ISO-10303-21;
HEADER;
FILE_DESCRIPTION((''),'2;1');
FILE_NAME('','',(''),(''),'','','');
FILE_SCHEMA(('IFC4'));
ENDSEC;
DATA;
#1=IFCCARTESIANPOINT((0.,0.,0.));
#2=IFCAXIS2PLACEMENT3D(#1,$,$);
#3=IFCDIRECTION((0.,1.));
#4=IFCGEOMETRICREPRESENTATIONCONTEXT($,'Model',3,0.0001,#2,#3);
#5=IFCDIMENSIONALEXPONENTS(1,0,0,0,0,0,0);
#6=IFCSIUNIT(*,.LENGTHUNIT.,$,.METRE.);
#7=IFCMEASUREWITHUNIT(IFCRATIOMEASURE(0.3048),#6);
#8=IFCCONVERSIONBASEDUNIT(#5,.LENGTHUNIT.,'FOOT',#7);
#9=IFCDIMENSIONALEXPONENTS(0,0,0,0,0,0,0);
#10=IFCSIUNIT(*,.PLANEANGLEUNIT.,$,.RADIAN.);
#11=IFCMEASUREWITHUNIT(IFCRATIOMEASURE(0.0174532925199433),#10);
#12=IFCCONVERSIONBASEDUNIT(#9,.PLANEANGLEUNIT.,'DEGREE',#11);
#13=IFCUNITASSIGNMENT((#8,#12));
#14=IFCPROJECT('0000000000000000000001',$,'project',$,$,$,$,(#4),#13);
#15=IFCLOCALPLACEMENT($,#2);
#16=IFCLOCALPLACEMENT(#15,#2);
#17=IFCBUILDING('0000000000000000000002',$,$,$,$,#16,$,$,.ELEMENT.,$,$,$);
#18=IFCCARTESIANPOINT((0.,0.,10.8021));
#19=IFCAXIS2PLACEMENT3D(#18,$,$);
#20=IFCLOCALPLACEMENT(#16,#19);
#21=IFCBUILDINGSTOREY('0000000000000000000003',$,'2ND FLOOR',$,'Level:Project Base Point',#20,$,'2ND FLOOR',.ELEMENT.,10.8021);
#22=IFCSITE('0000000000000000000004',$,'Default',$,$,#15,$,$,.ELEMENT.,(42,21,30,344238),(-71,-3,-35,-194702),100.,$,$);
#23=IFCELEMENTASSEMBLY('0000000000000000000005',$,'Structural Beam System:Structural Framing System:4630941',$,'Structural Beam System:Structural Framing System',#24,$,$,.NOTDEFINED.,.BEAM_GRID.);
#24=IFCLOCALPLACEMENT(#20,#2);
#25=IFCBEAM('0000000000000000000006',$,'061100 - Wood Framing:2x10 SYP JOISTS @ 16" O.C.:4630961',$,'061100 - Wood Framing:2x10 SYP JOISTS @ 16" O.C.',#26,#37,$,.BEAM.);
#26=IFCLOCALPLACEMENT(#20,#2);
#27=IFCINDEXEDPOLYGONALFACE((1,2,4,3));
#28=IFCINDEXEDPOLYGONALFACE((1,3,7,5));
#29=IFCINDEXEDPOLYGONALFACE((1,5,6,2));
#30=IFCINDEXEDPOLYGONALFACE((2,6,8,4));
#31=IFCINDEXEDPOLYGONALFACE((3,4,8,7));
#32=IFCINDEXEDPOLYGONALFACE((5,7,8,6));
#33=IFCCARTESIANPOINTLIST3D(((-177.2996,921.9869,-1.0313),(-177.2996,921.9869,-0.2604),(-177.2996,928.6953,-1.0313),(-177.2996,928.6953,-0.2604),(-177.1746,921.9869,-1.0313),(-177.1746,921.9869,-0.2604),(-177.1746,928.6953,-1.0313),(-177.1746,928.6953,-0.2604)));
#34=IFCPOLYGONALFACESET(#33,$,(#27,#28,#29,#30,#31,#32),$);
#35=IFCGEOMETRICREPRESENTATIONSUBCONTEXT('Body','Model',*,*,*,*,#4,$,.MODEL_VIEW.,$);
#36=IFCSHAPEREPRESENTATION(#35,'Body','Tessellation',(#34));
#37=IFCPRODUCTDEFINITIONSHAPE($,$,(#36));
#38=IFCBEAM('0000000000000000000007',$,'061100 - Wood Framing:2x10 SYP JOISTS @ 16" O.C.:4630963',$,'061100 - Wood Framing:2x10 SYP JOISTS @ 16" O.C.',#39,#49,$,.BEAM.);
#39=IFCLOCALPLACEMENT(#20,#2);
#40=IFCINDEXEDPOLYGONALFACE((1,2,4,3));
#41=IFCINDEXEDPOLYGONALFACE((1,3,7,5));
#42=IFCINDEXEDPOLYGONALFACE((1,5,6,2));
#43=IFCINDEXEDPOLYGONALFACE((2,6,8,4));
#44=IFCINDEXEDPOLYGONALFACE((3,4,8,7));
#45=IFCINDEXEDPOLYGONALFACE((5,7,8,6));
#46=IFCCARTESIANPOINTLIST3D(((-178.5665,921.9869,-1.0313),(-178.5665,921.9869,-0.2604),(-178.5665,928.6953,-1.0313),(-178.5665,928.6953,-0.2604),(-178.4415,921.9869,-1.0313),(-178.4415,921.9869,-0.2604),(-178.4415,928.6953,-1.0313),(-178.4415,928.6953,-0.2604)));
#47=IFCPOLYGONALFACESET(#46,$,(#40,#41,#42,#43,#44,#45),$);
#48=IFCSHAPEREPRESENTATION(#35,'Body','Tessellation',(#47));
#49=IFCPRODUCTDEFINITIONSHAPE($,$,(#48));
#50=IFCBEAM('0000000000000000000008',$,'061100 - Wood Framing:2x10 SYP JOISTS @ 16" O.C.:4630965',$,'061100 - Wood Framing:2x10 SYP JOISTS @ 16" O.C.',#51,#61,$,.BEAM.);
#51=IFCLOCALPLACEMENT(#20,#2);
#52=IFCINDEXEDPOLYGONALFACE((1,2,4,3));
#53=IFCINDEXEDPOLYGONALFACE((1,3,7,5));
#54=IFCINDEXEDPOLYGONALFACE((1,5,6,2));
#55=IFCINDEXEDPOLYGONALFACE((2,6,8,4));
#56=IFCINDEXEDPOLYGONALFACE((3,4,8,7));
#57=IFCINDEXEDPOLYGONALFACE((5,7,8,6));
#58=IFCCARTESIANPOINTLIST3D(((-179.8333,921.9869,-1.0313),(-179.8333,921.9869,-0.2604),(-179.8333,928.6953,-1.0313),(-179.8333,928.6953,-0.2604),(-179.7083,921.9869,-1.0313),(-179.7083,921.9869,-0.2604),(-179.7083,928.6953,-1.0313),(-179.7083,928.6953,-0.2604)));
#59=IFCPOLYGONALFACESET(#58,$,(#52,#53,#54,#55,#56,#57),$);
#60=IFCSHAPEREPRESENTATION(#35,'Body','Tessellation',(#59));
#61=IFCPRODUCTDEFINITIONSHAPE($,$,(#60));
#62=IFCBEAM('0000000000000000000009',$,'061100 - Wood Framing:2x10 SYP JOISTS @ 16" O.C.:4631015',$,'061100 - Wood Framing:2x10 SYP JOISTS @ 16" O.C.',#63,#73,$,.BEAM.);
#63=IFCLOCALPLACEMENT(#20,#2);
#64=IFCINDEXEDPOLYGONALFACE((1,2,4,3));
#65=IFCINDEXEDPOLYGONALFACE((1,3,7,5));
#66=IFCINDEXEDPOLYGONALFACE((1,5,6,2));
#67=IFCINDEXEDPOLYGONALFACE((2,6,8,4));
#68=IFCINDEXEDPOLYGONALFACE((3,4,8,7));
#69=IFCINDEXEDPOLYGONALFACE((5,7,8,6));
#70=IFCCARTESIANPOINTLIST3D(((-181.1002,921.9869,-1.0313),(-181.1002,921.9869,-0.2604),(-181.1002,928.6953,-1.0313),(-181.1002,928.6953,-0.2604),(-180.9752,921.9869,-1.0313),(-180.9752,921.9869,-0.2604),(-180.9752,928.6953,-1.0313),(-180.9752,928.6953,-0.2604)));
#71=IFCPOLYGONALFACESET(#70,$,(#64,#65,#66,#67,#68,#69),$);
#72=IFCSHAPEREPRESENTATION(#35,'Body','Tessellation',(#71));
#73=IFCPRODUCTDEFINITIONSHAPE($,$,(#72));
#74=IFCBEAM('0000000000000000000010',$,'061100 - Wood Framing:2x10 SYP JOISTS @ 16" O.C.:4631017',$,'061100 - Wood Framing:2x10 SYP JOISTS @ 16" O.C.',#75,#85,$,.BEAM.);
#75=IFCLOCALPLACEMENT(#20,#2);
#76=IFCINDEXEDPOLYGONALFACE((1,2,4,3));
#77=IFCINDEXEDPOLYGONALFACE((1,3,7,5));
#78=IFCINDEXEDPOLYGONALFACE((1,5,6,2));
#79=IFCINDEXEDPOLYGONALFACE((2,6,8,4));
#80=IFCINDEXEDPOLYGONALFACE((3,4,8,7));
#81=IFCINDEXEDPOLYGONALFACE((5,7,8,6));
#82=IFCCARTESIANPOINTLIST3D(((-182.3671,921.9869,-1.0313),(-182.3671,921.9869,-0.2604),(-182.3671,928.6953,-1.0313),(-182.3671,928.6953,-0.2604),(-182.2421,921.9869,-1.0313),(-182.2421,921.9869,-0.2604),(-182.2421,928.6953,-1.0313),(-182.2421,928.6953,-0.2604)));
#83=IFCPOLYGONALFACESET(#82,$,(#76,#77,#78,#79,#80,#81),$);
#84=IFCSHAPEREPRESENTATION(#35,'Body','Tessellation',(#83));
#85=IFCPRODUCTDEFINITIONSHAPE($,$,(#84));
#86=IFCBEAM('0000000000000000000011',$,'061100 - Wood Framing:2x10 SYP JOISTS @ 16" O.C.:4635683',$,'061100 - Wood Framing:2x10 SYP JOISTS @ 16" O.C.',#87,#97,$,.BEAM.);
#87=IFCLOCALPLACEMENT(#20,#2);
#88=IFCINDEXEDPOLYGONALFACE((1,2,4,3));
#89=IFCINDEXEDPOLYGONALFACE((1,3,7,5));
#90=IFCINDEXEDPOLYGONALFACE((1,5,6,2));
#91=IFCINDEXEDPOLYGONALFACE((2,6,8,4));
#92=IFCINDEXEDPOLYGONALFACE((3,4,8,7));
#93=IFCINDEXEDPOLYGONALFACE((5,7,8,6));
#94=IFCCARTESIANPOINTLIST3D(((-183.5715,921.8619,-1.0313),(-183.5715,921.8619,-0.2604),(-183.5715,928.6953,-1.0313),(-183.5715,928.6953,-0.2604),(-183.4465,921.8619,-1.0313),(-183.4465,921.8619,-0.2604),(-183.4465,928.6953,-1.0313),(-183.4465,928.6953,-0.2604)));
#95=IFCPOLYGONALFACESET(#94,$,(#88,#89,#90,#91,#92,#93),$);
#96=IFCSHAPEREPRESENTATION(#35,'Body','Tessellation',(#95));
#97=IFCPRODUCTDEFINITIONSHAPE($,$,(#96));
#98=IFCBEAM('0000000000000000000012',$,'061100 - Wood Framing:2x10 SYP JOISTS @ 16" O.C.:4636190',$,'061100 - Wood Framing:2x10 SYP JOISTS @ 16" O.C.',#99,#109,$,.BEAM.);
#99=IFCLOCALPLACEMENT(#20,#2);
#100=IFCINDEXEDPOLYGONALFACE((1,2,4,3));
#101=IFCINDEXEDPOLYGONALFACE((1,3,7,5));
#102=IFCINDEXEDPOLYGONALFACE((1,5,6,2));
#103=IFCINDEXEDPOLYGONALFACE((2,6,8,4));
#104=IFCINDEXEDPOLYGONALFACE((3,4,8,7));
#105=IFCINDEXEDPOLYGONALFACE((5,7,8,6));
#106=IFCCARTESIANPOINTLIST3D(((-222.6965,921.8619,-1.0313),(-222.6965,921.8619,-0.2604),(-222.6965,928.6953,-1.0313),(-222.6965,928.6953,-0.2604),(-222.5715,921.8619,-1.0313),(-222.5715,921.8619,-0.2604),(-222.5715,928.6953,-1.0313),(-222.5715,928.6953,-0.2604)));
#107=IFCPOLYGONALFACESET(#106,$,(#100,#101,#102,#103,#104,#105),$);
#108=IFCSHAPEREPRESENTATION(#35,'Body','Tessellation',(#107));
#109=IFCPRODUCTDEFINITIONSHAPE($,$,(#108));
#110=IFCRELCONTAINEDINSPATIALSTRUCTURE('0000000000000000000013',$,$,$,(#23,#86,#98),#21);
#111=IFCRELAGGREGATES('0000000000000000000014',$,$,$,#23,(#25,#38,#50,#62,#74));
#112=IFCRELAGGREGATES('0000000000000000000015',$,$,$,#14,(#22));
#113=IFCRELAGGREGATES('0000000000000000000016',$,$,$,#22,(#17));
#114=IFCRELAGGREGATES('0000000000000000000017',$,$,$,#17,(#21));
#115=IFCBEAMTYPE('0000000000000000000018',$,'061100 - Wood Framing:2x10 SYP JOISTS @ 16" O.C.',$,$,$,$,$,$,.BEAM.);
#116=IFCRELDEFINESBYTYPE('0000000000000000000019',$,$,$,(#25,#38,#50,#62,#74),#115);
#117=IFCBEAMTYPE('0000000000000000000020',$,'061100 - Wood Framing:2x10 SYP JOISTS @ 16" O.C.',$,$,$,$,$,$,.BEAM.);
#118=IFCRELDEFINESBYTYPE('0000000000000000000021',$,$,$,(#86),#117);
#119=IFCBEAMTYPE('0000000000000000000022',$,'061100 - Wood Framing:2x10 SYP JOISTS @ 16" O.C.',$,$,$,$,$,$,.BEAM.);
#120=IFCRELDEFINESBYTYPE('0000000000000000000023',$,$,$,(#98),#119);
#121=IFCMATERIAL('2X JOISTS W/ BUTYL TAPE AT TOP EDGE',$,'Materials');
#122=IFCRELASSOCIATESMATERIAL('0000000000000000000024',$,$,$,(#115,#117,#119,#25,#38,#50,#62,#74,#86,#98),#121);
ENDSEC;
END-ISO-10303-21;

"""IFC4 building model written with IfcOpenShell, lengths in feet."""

from ifc_helpers import new_model, entity, si_unit, converted_unit, direction, frame, frame_2d, origin, origin_2d_with_axis, place, context, subcontext, project, spatial, rectangle, extrude, source, transform, mapped, material, material_profile, profile_set, profile_usage, type_object, type_shapes, element, aggregate, save


model = new_model("IFC4")

# Units and contexts
model_context = context("Model", 3, precision=0.0001, world=origin(), true_north=direction((0.0, 1.0)))
body_context = subcontext(model_context, "Body", "Model", "MODEL_VIEW")
ifc_project = project(units=[converted_unit("LENGTHUNIT", "FOOT", entity("IfcRatioMeasure", 0.3048), si_unit("LENGTHUNIT", "METRE"), dimensions=[1, 0, 0, 0, 0, 0, 0]), converted_unit("PLANEANGLEUNIT", "DEGREE", entity("IfcRatioMeasure", 0.0174532925199433), si_unit("PLANEANGLEUNIT", "RADIAN"), dimensions=[0, 0, 0, 0, 0, 0, 0])], contexts=[model_context])

# Site, building, storey
site_placement = place(None, origin())
site = spatial("IfcSite", under=ifc_project, at=site_placement, Name="Default", CompositionType="ELEMENT", RefLatitude=(42, 21, 30, 344238), RefLongitude=(-71, -3, -35, -194702), RefElevation=100.0)
building_placement = place(site_placement, origin())
building = spatial("IfcBuilding", under=site, at=building_placement, CompositionType="ELEMENT")
storey_placement = place(building_placement, frame((0.0, 0.0, 10.8021)))
storey = spatial("IfcBuildingStorey", under=building, at=storey_placement, Name="2ND FLOOR", ObjectType="Level:Project Base Point", LongName="2ND FLOOR", CompositionType="ELEMENT", Elevation=10.8021)

# Element assembly, beams
ifc_material_1 = material(Name="2X JOISTS W/ BUTYL TAPE AT TOP EDGE", Category="Materials")
ifc_material_profile_1 = material_profile(ifc_material_1, rectangle(XDim=0.7708, YDim=0.125, at=frame_2d((0.0, 0.0), x_axis=(1.0, 0.0))), Name="2x10 SYP JOISTS @ 16\" O.C.")
ifc_profile_set_1 = profile_set([ifc_material_profile_1], Name="2x10 SYP JOISTS @ 16\" O.C.")
beam_type_1 = type_object("IfcBeamType", Name="061100 - Wood Framing:2x10 SYP JOISTS @ 16\" O.C.", PredefinedType="BEAM", material=ifc_profile_set_1)
shared_shape_1 = source(origin(), body_context, "Body", "SweptSolid", [
    extrude(rectangle(XDim=0.7708, YDim=0.125, at=frame_2d((0.0, 0.0), x_axis=(1.0, 0.0))), frame((-3.3542, 0.0, 0.0), z_axis=(1.0, 0.0, 0.0), x_axis=(0.0, 0.0, -1.0)), (0.0, 0.0, 1.0), 6.7083),
])
type_shapes(beam_type_1, [shared_shape_1])
assembly_1_placement = place(storey_placement, origin())
assembly_1 = element("IfcElementAssembly", 1, at=assembly_1_placement, inside=storey, Name="Structural Beam System:Structural Framing System:4630941", ObjectType="Structural Beam System:Structural Framing System", AssemblyPlace="NOTDEFINED", PredefinedType="BEAM_GRID")
ifc_profile_usage_1 = profile_usage(ifc_profile_set_1, cardinal=8)
beam_1_placement = place(assembly_1_placement, frame((-177.2371, 925.3411, -0.6458), z_axis=(0.0, 0.0, 1.0), x_axis=(0.0, 1.0, 0.0)))
beam_1 = element("IfcBeam", 2, at=beam_1_placement, type_object=beam_type_1, material=ifc_profile_usage_1, Name="061100 - Wood Framing:2x10 SYP JOISTS @ 16\" O.C.:4630961", ObjectType="061100 - Wood Framing:2x10 SYP JOISTS @ 16\" O.C.", PredefinedType="BEAM", context=body_context, shape_type="MappedRepresentation", body=[
    mapped(shared_shape_1, transform((0.0, 0.0, 0.0), scale=1.0)),
])
ifc_profile_usage_2 = profile_usage(ifc_profile_set_1, cardinal=8)
beam_2_placement = place(assembly_1_placement, frame((-178.504, 925.3411, -0.6458), z_axis=(0.0, 0.0, 1.0), x_axis=(0.0, 1.0, 0.0)))
beam_2 = element("IfcBeam", 3, at=beam_2_placement, type_object=beam_type_1, material=ifc_profile_usage_2, Name="061100 - Wood Framing:2x10 SYP JOISTS @ 16\" O.C.:4630963", ObjectType="061100 - Wood Framing:2x10 SYP JOISTS @ 16\" O.C.", PredefinedType="BEAM", context=body_context, shape_type="MappedRepresentation", body=[
    mapped(shared_shape_1, transform((0.0, 0.0, 0.0), scale=1.0)),
])
ifc_profile_usage_3 = profile_usage(ifc_profile_set_1, cardinal=8)
beam_3_placement = place(assembly_1_placement, frame((-179.7708, 925.3411, -0.6458), z_axis=(0.0, 0.0, 1.0), x_axis=(0.0, 1.0, 0.0)))
beam_3 = element("IfcBeam", 4, at=beam_3_placement, type_object=beam_type_1, material=ifc_profile_usage_3, Name="061100 - Wood Framing:2x10 SYP JOISTS @ 16\" O.C.:4630965", ObjectType="061100 - Wood Framing:2x10 SYP JOISTS @ 16\" O.C.", PredefinedType="BEAM", context=body_context, shape_type="MappedRepresentation", body=[
    mapped(shared_shape_1, transform((0.0, 0.0, 0.0), scale=1.0)),
])
ifc_profile_usage_4 = profile_usage(ifc_profile_set_1, cardinal=8)
beam_4_placement = place(assembly_1_placement, frame((-181.0377, 925.3411, -0.6458), z_axis=(0.0, 0.0, 1.0), x_axis=(0.0, 1.0, 0.0)))
beam_4 = element("IfcBeam", 5, at=beam_4_placement, type_object=beam_type_1, material=ifc_profile_usage_4, Name="061100 - Wood Framing:2x10 SYP JOISTS @ 16\" O.C.:4631015", ObjectType="061100 - Wood Framing:2x10 SYP JOISTS @ 16\" O.C.", PredefinedType="BEAM", context=body_context, shape_type="MappedRepresentation", body=[
    mapped(shared_shape_1, transform((0.0, 0.0, 0.0), scale=1.0)),
])
ifc_profile_usage_5 = profile_usage(ifc_profile_set_1, cardinal=8)
beam_5_placement = place(assembly_1_placement, frame((-182.3046, 925.3411, -0.6458), z_axis=(0.0, 0.0, 1.0), x_axis=(0.0, 1.0, 0.0)))
beam_5 = element("IfcBeam", 6, at=beam_5_placement, type_object=beam_type_1, material=ifc_profile_usage_5, Name="061100 - Wood Framing:2x10 SYP JOISTS @ 16\" O.C.:4631017", ObjectType="061100 - Wood Framing:2x10 SYP JOISTS @ 16\" O.C.", PredefinedType="BEAM", context=body_context, shape_type="MappedRepresentation", body=[
    mapped(shared_shape_1, transform((0.0, 0.0, 0.0), scale=1.0)),
])
aggregate(assembly_1, [beam_1, beam_2, beam_3, beam_4, beam_5])

# Beams
ifc_profile_usage_6 = profile_usage(ifc_profile_set_1, cardinal=8)
beam_type_2 = type_object("IfcBeamType", Name="061100 - Wood Framing:2x10 SYP JOISTS @ 16\" O.C.", PredefinedType="BEAM", material=ifc_profile_set_1)
shared_shape_2 = source(origin(), body_context, "Body", "SweptSolid", [
    extrude(rectangle(XDim=0.7708, YDim=0.125, at=frame_2d((0.0, 0.0), x_axis=(1.0, 0.0))), frame((-3.4792, 0.0, 0.0), z_axis=(1.0, 0.0, 0.0), x_axis=(0.0, 0.0, -1.0)), (0.0, 0.0, 1.0), 6.8333),
])
type_shapes(beam_type_2, [shared_shape_2])
beam_6_placement = place(storey_placement, frame((-183.509, 925.3411, -0.6458), z_axis=(0.0, 0.0, 1.0), x_axis=(0.0, 1.0, 0.0)))
element("IfcBeam", 7, at=beam_6_placement, inside=storey, type_object=beam_type_2, material=ifc_profile_usage_6, Name="061100 - Wood Framing:2x10 SYP JOISTS @ 16\" O.C.:4635683", ObjectType="061100 - Wood Framing:2x10 SYP JOISTS @ 16\" O.C.", PredefinedType="BEAM", context=body_context, shape_type="MappedRepresentation", body=[
    mapped(shared_shape_2, transform((0.0, 0.0, 0.0), scale=1.0)),
])
ifc_profile_usage_7 = profile_usage(ifc_profile_set_1, cardinal=8)
beam_type_3 = type_object("IfcBeamType", Name="061100 - Wood Framing:2x10 SYP JOISTS @ 16\" O.C.", PredefinedType="BEAM", material=ifc_profile_set_1)
shared_shape_3 = source(origin(), body_context, "Body", "SweptSolid", [
    extrude(rectangle(XDim=0.7708, YDim=0.125, at=origin_2d_with_axis()), frame((-3.4792, 0.0, 0.0), z_axis=(1.0, 0.0, 0.0), x_axis=(0.0, 0.0, -1.0)), (0.0, 0.0, 1.0), 6.8333),
])
type_shapes(beam_type_3, [shared_shape_3])
beam_7_placement = place(storey_placement, frame((-222.634, 925.3411, -0.6458), z_axis=(0.0, 0.0, 1.0), x_axis=(0.0, 1.0, 0.0)))
element("IfcBeam", 8, at=beam_7_placement, inside=storey, type_object=beam_type_3, material=ifc_profile_usage_7, Name="061100 - Wood Framing:2x10 SYP JOISTS @ 16\" O.C.:4636190", ObjectType="061100 - Wood Framing:2x10 SYP JOISTS @ 16\" O.C.", PredefinedType="BEAM", context=body_context, shape_type="MappedRepresentation", body=[
    mapped(shared_shape_3, transform((0.0, 0.0, 0.0), scale=1.0)),
])

save(model, "model.ifc")
